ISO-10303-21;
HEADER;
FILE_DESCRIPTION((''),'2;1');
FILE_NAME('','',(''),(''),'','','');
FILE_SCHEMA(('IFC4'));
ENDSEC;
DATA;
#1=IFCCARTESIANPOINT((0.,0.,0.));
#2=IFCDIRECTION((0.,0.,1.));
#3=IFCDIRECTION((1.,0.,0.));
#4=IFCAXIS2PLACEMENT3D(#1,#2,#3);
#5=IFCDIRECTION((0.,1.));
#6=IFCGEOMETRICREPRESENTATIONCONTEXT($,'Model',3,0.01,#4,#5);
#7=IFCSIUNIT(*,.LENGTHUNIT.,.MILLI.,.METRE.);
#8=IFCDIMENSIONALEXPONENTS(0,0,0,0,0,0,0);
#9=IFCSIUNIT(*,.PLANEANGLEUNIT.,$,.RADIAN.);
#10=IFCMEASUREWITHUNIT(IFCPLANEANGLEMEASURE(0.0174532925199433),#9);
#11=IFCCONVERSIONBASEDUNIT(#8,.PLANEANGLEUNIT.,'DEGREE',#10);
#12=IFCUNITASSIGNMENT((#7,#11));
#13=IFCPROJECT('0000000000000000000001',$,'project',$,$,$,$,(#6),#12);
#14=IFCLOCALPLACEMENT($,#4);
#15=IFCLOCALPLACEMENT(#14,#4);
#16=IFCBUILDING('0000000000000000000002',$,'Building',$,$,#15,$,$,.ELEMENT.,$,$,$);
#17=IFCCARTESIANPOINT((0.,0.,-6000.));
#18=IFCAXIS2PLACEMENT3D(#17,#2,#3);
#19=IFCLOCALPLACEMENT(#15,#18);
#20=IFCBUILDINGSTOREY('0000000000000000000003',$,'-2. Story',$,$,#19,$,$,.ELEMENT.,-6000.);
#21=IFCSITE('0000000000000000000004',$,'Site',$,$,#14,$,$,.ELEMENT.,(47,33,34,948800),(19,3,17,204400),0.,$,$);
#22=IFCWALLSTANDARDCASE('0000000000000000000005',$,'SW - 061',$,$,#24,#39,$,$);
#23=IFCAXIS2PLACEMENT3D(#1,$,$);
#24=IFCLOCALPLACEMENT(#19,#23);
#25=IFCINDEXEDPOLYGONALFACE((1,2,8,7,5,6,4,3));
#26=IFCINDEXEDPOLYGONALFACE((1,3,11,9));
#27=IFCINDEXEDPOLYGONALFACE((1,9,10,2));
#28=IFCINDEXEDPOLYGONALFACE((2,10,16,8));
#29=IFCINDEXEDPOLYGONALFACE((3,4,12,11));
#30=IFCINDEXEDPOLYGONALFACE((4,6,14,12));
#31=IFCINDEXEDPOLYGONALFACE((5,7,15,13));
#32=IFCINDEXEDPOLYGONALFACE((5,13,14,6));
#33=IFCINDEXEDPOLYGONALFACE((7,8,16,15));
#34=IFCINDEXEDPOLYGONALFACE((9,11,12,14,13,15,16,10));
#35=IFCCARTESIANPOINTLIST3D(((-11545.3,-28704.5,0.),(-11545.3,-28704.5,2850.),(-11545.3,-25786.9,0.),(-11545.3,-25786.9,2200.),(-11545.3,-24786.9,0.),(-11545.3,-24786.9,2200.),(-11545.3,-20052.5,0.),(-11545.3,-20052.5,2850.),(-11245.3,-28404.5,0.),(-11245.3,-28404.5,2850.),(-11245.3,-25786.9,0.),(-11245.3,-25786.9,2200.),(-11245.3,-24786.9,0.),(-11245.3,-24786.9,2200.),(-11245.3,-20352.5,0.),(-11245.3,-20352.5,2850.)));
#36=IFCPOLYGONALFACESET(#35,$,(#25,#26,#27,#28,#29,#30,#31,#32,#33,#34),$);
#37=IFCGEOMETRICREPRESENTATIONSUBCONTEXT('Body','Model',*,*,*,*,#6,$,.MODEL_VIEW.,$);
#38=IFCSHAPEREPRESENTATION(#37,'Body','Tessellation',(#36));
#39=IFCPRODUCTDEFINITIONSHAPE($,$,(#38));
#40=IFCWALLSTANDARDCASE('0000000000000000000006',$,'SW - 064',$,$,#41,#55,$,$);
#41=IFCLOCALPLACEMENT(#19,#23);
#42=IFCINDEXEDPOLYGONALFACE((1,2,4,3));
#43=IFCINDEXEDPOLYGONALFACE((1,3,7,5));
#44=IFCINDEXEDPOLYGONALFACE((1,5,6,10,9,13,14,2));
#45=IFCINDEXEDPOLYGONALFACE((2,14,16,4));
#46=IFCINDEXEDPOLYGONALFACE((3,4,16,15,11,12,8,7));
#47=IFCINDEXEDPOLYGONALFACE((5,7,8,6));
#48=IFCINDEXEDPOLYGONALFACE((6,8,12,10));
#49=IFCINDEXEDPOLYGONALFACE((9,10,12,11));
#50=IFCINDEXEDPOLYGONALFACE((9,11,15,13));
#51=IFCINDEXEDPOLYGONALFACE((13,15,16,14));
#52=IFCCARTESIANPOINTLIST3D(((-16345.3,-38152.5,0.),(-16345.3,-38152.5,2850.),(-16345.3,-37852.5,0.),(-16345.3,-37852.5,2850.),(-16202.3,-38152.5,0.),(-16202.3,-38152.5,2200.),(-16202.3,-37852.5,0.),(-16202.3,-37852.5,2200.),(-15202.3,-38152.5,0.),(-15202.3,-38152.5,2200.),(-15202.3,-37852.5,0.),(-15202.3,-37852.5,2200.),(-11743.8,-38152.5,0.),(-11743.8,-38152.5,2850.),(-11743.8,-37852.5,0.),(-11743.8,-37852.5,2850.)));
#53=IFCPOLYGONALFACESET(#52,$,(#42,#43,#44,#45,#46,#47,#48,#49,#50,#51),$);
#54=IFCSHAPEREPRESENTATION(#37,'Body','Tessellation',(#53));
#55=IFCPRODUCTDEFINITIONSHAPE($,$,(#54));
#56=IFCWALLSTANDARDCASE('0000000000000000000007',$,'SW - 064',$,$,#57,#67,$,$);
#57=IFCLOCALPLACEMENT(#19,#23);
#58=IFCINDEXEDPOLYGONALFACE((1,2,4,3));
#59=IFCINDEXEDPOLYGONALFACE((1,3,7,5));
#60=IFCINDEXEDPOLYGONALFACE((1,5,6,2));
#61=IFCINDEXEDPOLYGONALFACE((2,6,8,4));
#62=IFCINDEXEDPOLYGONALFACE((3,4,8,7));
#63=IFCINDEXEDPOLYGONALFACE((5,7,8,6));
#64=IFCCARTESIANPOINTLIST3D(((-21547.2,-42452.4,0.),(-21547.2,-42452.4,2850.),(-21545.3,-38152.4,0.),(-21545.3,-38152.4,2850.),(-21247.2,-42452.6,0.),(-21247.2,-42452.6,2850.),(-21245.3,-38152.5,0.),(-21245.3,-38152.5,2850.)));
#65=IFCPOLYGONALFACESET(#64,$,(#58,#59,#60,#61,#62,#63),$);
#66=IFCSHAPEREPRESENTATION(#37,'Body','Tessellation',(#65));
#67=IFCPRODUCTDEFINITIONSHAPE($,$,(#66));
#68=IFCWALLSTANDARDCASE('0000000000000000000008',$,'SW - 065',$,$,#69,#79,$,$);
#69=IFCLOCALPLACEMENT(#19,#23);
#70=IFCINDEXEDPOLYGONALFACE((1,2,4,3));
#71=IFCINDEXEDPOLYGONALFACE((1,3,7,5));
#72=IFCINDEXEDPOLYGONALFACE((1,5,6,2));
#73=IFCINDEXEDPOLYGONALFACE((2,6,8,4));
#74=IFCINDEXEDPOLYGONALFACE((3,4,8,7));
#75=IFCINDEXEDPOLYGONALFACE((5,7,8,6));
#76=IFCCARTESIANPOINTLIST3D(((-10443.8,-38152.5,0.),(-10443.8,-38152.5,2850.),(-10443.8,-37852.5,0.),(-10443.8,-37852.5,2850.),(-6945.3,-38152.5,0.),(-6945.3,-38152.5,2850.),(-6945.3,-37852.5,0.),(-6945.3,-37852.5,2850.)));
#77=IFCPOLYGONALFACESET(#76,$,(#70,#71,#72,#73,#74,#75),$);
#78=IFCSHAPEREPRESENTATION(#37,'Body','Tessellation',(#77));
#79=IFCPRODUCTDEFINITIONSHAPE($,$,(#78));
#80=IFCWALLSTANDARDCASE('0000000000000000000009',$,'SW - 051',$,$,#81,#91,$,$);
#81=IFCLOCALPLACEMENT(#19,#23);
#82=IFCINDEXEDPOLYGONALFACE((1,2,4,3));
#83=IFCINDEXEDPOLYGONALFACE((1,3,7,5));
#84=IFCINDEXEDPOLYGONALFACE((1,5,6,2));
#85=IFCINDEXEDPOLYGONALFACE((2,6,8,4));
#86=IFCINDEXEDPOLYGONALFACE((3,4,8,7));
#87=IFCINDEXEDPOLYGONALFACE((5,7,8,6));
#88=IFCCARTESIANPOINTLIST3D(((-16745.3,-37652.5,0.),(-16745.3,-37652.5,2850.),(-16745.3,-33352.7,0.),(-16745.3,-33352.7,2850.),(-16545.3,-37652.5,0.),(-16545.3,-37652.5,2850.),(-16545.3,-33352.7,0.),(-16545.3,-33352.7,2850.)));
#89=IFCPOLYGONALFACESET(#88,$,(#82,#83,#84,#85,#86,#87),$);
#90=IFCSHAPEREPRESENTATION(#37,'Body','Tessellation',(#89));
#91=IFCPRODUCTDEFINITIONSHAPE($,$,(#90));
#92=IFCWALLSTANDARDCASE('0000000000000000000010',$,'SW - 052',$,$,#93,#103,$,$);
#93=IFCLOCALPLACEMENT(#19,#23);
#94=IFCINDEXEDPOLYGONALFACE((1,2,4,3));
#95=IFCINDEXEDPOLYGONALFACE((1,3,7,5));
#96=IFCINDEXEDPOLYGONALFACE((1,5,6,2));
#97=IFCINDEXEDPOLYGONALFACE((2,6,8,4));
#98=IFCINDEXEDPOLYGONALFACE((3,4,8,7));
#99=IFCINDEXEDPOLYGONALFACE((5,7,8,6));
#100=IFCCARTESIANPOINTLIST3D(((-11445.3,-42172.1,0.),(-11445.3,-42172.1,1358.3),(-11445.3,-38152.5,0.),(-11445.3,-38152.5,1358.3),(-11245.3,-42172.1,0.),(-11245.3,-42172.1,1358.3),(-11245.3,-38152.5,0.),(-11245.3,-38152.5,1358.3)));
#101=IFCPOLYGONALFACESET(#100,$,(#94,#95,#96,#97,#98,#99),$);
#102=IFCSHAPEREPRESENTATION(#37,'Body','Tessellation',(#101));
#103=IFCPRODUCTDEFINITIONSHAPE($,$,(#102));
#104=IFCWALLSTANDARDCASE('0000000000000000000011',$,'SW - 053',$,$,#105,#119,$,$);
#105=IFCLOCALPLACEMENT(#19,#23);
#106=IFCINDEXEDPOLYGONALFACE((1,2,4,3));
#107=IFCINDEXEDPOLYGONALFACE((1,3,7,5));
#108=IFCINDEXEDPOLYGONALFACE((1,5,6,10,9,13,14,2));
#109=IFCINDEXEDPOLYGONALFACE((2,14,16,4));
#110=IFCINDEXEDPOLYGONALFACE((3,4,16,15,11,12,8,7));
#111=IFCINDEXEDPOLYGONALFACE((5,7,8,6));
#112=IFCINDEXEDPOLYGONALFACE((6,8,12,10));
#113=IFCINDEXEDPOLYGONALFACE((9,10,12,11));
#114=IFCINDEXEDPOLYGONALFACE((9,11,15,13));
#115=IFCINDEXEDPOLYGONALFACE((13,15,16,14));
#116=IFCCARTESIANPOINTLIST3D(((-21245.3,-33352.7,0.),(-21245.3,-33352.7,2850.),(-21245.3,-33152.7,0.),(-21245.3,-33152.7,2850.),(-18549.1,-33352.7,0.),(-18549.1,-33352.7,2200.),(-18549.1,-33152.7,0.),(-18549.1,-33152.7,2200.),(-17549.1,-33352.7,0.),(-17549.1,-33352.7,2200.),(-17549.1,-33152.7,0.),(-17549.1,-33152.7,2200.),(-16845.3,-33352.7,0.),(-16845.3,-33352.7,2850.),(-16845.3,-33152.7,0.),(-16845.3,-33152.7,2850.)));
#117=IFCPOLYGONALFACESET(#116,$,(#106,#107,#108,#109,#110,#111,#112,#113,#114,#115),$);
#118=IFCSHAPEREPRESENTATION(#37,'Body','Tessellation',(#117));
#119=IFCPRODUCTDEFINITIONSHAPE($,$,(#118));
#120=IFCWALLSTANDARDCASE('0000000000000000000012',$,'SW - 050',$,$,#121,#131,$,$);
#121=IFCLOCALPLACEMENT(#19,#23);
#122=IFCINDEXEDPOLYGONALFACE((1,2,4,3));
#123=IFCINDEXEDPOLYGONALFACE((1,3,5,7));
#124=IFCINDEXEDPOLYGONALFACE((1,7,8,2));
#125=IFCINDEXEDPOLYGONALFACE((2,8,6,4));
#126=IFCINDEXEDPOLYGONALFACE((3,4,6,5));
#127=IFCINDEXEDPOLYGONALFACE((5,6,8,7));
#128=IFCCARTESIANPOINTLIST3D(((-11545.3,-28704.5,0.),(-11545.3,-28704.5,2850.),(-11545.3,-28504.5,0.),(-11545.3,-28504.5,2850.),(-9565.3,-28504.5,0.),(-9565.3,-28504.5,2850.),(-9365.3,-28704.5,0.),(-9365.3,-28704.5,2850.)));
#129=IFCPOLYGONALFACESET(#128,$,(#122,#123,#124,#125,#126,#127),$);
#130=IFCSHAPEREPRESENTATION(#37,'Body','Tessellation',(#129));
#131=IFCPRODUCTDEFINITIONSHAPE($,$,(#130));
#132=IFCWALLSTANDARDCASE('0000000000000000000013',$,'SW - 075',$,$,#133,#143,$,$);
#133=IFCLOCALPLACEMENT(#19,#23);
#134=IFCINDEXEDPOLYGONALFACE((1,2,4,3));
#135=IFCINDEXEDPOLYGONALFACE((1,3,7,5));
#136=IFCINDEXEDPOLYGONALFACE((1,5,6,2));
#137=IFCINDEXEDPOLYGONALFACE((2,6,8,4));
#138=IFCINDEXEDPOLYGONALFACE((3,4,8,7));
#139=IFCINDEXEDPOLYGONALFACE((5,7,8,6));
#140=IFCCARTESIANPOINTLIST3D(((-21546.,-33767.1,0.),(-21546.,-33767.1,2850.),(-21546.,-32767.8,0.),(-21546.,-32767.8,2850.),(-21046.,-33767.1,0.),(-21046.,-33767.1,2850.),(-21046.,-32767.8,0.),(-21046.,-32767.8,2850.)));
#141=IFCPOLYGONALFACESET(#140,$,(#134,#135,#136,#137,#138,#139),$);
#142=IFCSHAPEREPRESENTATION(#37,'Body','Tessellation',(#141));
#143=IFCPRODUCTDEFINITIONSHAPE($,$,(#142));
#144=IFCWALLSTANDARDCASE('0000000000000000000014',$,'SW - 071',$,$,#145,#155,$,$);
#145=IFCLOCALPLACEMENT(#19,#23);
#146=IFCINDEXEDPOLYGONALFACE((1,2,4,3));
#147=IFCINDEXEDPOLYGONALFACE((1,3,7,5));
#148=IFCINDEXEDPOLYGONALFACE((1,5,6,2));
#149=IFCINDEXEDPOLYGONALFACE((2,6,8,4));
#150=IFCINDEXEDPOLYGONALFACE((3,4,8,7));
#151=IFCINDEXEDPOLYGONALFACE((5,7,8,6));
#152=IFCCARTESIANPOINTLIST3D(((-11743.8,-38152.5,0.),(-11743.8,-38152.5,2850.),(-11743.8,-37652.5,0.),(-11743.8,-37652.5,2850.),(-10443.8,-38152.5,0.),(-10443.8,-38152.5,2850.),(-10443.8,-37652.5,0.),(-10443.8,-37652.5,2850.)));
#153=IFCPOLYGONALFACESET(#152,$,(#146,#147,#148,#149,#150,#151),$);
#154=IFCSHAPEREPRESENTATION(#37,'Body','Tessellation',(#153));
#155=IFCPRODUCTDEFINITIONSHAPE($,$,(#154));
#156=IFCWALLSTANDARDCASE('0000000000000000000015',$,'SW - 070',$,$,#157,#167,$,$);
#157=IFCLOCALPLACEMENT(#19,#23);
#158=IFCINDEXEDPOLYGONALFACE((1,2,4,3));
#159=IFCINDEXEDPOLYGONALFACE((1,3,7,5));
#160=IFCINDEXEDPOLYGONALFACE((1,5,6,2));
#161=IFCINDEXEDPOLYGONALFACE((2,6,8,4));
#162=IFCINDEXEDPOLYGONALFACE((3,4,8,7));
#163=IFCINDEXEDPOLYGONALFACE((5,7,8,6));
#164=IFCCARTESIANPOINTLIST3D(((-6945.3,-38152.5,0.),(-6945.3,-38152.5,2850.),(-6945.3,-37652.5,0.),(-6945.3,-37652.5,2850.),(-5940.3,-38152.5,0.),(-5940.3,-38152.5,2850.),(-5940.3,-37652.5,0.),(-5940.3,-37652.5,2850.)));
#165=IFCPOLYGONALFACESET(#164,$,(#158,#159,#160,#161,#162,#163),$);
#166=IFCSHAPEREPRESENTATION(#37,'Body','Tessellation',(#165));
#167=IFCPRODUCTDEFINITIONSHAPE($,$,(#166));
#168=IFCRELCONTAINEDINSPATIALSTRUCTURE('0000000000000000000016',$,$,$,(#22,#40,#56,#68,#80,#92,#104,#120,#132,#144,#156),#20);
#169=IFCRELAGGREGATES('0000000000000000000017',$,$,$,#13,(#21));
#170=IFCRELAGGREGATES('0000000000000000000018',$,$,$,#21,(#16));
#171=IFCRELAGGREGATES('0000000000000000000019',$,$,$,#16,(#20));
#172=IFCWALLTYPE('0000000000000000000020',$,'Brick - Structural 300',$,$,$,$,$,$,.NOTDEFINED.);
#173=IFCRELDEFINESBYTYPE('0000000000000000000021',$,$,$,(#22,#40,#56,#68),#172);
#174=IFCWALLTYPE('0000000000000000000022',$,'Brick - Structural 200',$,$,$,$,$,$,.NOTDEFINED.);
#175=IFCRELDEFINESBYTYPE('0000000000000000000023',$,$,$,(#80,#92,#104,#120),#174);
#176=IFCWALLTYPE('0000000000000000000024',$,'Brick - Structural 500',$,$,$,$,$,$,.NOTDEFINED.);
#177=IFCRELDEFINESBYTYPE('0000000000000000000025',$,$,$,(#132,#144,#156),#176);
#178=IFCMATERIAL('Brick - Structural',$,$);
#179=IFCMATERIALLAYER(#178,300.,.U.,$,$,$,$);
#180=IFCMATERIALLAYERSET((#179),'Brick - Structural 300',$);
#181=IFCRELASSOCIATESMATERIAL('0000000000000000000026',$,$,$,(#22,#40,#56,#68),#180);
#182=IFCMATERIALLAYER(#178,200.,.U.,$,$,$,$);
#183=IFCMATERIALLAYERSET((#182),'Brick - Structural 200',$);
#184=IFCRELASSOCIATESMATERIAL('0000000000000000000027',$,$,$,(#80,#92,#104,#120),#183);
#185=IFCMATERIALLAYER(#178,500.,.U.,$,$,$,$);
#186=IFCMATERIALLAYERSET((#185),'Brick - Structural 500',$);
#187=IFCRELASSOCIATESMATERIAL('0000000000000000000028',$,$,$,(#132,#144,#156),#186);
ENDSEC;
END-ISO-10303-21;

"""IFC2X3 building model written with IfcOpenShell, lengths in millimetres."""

from ifc_helpers import new_model, entity, si_unit, converted_unit, direction, frame, origin_with_axes, origin_2d_with_axis, place, context, subcontext, project, spatial, polyline, rectangle, outline, extrude, material, layer, layer_set, layer_usage, type_object, element, save


model = new_model("IFC2X3")

# Units and contexts
model_context = context("Model", 3, precision=0.01, world=origin_with_axes(), true_north=direction((0.0, 1.0)))
body_context = subcontext(model_context, "Body", "Model", "MODEL_VIEW")
ifc_project = project(units=[si_unit("LENGTHUNIT", "METRE", prefix="MILLI"), converted_unit("PLANEANGLEUNIT", "DEGREE", entity("IfcPlaneAngleMeasure", 0.0174532925199433), si_unit("PLANEANGLEUNIT", "RADIAN"), dimensions=[0, 0, 0, 0, 0, 0, 0])], contexts=[model_context])

# Site, building, storey
site_placement = place(None, origin_with_axes())
site = spatial("IfcSite", under=ifc_project, at=site_placement, Name="Site", CompositionType="ELEMENT", RefLatitude=(47, 33, 34, 948800), RefLongitude=(19, 3, 17, 204400), RefElevation=0.0)
building_placement = place(site_placement, origin_with_axes())
building = spatial("IfcBuilding", under=site, at=building_placement, Name="Building", CompositionType="ELEMENT")
storey_placement = place(building_placement, frame((0.0, 0.0, -6000.0), z_axis=(0.0, 0.0, 1.0), x_axis=(1.0, 0.0, 0.0)))
storey = spatial("IfcBuildingStorey", under=building, at=storey_placement, Name="-2. Story", CompositionType="ELEMENT", Elevation=-6000.0)

# Shared definitions
ifc_material_1 = material(Name="Brick - Structural")
ifc_layer_1 = layer(ifc_material_1, 300.0, ventilated="UNKNOWN")
ifc_layer_set_1 = layer_set([ifc_layer_1], Name="Brick - Structural 300")
wall_type_1 = type_object("IfcWallType", Name="Brick - Structural 300", PredefinedType="NOTDEFINED")

# Walls, openings
ifc_layer_usage_1 = layer_usage(ifc_layer_set_1, "AXIS2", "NEGATIVE", 0.0)
wall_1_placement = place(storey_placement, frame((-11545.3, -28704.5, 0.0), z_axis=(0.0, 0.0, 1.0), x_axis=(0.0, 1.0, 0.0)))
wall_1 = element("IfcWallStandardCase", 1, at=wall_1_placement, inside=storey, type_object=wall_type_1, material=ifc_layer_usage_1, Name="SW - 061", context=body_context, shape_type="SweptSolid", body=[
    extrude(outline(polyline([(300.0, -300.0), (8351.9, -300.0), (8651.9, 0.0), (0.0, 0.0), (300.0, -300.0)])), origin_with_axes(), (0.0, 0.0, 1.0), 2850.0),
])
opening_1_placement = place(wall_1_placement, frame((3417.6, 0.0, 0.0), z_axis=(0.0, 0.0, 1.0), x_axis=(1.0, 0.0, 0.0)))
element("IfcOpeningElement", 2, at=opening_1_placement, cuts=wall_1, context=body_context, shape_type="SweptSolid", body=[
    extrude(rectangle(XDim=1000.0, YDim=2200.0, at=origin_2d_with_axis()), frame((0.0, -300.0, 1100.0), z_axis=(0.0, 1.0, 0.0), x_axis=(1.0, 0.0, 0.0)), (0.0, 0.0, -1.0), 300.0),
    extrude(rectangle(XDim=1000.0, YDim=2200.0, at=origin_2d_with_axis()), frame((0.0, -300.0, 1100.0), z_axis=(0.0, -1.0, 0.0), x_axis=(1.0, 0.0, 0.0)), (0.0, 0.0, -1.0), 300.0),
])
ifc_layer_usage_2 = layer_usage(ifc_layer_set_1, "AXIS2", "POSITIVE", 0.0)
wall_2_placement = place(storey_placement, frame((-16345.3, -38152.5, 0.0), z_axis=(0.0, 0.0, 1.0), x_axis=(1.0, 0.0, 0.0)))
wall_2 = element("IfcWallStandardCase", 3, at=wall_2_placement, inside=storey, type_object=wall_type_1, material=ifc_layer_usage_2, Name="SW - 064", context=body_context, shape_type="SweptSolid", body=[
    extrude(outline(polyline([(0.0, 0.0), (4601.5, 0.0), (4601.5, 300.0), (0.0, 300.0), (0.0, 0.0)])), origin_with_axes(), (0.0, 0.0, 1.0), 2850.0),
])
opening_2_placement = place(wall_2_placement, frame((643.0, 0.0, 0.0), z_axis=(0.0, 0.0, 1.0), x_axis=(1.0, 0.0, 0.0)))
element("IfcOpeningElement", 4, at=opening_2_placement, cuts=wall_2, context=body_context, shape_type="SweptSolid", body=[
    extrude(rectangle(XDim=1000.0, YDim=2200.0, at=origin_2d_with_axis()), frame((0.0, 300.0, 1100.0), z_axis=(0.0, -1.0, 0.0), x_axis=(1.0, 0.0, 0.0)), (0.0, 0.0, -1.0), 300.0),
    extrude(rectangle(XDim=1000.0, YDim=2200.0, at=origin_2d_with_axis()), frame((0.0, 300.0, 1100.0), z_axis=(0.0, 1.0, 0.0), x_axis=(1.0, 0.0, 0.0)), (0.0, 0.0, -1.0), 300.0),
])

# Walls
ifc_layer_usage_3 = layer_usage(ifc_layer_set_1, "AXIS2", "POSITIVE", 0.0)
wall_3_placement = place(storey_placement, frame((-21247.2, -42452.6, 0.0), z_axis=(0.0, 0.0, 1.0), x_axis=(0.00044, 1.0, 0.0)))
element("IfcWallStandardCase", 5, at=wall_3_placement, inside=storey, type_object=wall_type_1, material=ifc_layer_usage_3, Name="SW - 064", context=body_context, shape_type="SweptSolid", body=[
    extrude(outline(polyline([(0.0, 0.0), (4300.1, 0.0), (4300.1, 300.0), (0.0, 300.0), (0.0, 0.0)])), origin_with_axes(), (0.0, 0.0, 1.0), 2850.0),
])
ifc_layer_usage_4 = layer_usage(ifc_layer_set_1, "AXIS2", "POSITIVE", 0.0)
wall_4_placement = place(storey_placement, frame((-10443.8, -38152.5, 0.0), z_axis=(0.0, 0.0, 1.0), x_axis=(1.0, 0.0, 0.0)))
element("IfcWallStandardCase", 6, at=wall_4_placement, inside=storey, type_object=wall_type_1, material=ifc_layer_usage_4, Name="SW - 065", context=body_context, shape_type="SweptSolid", body=[
    extrude(outline(polyline([(0.0, 0.0), (3498.5, 0.0), (3498.5, 300.0), (0.0, 300.0), (0.0, 0.0)])), origin_with_axes(), (0.0, 0.0, 1.0), 2850.0),
])
ifc_layer_2 = layer(ifc_material_1, 200.0, ventilated="UNKNOWN")
ifc_layer_set_2 = layer_set([ifc_layer_2], Name="Brick - Structural 200")
ifc_layer_usage_5 = layer_usage(ifc_layer_set_2, "AXIS2", "NEGATIVE", 0.0)
wall_type_2 = type_object("IfcWallType", Name="Brick - Structural 200", PredefinedType="NOTDEFINED")
wall_5_placement = place(storey_placement, frame((-16545.3, -33352.7, 0.0), z_axis=(0.0, 0.0, 1.0), x_axis=(0.0, -1.0, 0.0)))
element("IfcWallStandardCase", 7, at=wall_5_placement, inside=storey, type_object=wall_type_2, material=ifc_layer_usage_5, Name="SW - 051", context=body_context, shape_type="SweptSolid", body=[
    extrude(outline(polyline([(0.0, -200.0), (4299.9, -200.0), (4299.9, 0.0), (0.0, 0.0), (0.0, -200.0)])), origin_with_axes(), (0.0, 0.0, 1.0), 2850.0),
])
ifc_layer_usage_6 = layer_usage(ifc_layer_set_2, "AXIS2", "POSITIVE", 0.0)
wall_6_placement = place(storey_placement, frame((-11445.3, -38152.5, 0.0), z_axis=(0.0, 0.0, 1.0), x_axis=(0.0, -1.0, 0.0)))
element("IfcWallStandardCase", 8, at=wall_6_placement, inside=storey, type_object=wall_type_2, material=ifc_layer_usage_6, Name="SW - 052", context=body_context, shape_type="SweptSolid", body=[
    extrude(outline(polyline([(0.0, 0.0), (4019.6, 0.0), (4019.6, 200.0), (0.0, 200.0), (0.0, 0.0)])), origin_with_axes(), (0.0, 0.0, 1.0), 1358.3),
])

# Wall, opening
ifc_layer_usage_7 = layer_usage(ifc_layer_set_2, "AXIS2", "POSITIVE", 0.0)
wall_7_placement = place(storey_placement, frame((-16845.3, -33152.7, 0.0), z_axis=(0.0, 0.0, 1.0), x_axis=(-1.0, 0.0, 0.0)))
wall_7 = element("IfcWallStandardCase", 9, at=wall_7_placement, inside=storey, type_object=wall_type_2, material=ifc_layer_usage_7, Name="SW - 053", context=body_context, shape_type="SweptSolid", body=[
    extrude(outline(polyline([(0.0, 0.0), (4400.0, 0.0), (4400.0, 200.0), (0.0, 200.0), (0.0, 0.0)])), origin_with_axes(), (0.0, 0.0, 1.0), 2850.0),
])
opening_3_placement = place(wall_7_placement, frame((1203.8, 0.0, 0.0), z_axis=(0.0, 0.0, 1.0), x_axis=(1.0, 0.0, 0.0)))
element("IfcOpeningElement", 10, at=opening_3_placement, cuts=wall_7, context=body_context, shape_type="SweptSolid", body=[
    extrude(rectangle(XDim=1000.0, YDim=2200.0, at=origin_2d_with_axis()), frame((0.0, 200.0, 1100.0), z_axis=(0.0, -1.0, 0.0), x_axis=(1.0, 0.0, 0.0)), (0.0, 0.0, -1.0), 200.0),
    extrude(rectangle(XDim=1000.0, YDim=2200.0, at=origin_2d_with_axis()), frame((0.0, 200.0, 1100.0), z_axis=(0.0, 1.0, 0.0), x_axis=(1.0, 0.0, 0.0)), (0.0, 0.0, -1.0), 200.0),
])

# Walls
ifc_layer_usage_8 = layer_usage(ifc_layer_set_2, "AXIS2", "POSITIVE", 0.0)
wall_8_placement = place(storey_placement, frame((-11545.3, -28704.5, 0.0), z_axis=(0.0, 0.0, 1.0), x_axis=(1.0, 0.0, 0.0)))
element("IfcWallStandardCase", 11, at=wall_8_placement, inside=storey, type_object=wall_type_2, material=ifc_layer_usage_8, Name="SW - 050", context=body_context, shape_type="SweptSolid", body=[
    extrude(outline(polyline([(0.0, 0.0), (2180.0, 0.0), (1980.0, 200.0), (0.0, 200.0), (0.0, 0.0)])), origin_with_axes(), (0.0, 0.0, 1.0), 2850.0),
])
ifc_layer_3 = layer(ifc_material_1, 500.0, ventilated="UNKNOWN")
ifc_layer_set_3 = layer_set([ifc_layer_3], Name="Brick - Structural 500")
ifc_layer_usage_9 = layer_usage(ifc_layer_set_3, "AXIS2", "NEGATIVE", 0.0)
wall_type_3 = type_object("IfcWallType", Name="Brick - Structural 500", PredefinedType="NOTDEFINED")
wall_9_placement = place(storey_placement, frame((-21546.0, -33767.1, 0.0), z_axis=(0.0, 0.0, 1.0), x_axis=(0.0, 1.0, 0.0)))
element("IfcWallStandardCase", 12, at=wall_9_placement, inside=storey, type_object=wall_type_3, material=ifc_layer_usage_9, Name="SW - 075", context=body_context, shape_type="SweptSolid", body=[
    extrude(outline(polyline([(0.0, -500.0), (999.3, -500.0), (999.3, 0.0), (0.0, 0.0), (0.0, -500.0)])), origin_with_axes(), (0.0, 0.0, 1.0), 2850.0),
])
ifc_layer_usage_10 = layer_usage(ifc_layer_set_3, "AXIS2", "NEGATIVE", 0.0)
wall_10_placement = place(storey_placement, frame((-10443.8, -38152.5, 0.0), z_axis=(0.0, 0.0, 1.0), x_axis=(-1.0, 0.0, 0.0)))
element("IfcWallStandardCase", 13, at=wall_10_placement, inside=storey, type_object=wall_type_3, material=ifc_layer_usage_10, Name="SW - 071", context=body_context, shape_type="SweptSolid", body=[
    extrude(outline(polyline([(0.0, -500.0), (1300.0, -500.0), (1300.0, 0.0), (0.0, 0.0), (0.0, -500.0)])), origin_with_axes(), (0.0, 0.0, 1.0), 2850.0),
])
ifc_layer_usage_11 = layer_usage(ifc_layer_set_3, "AXIS2", "NEGATIVE", 0.0)
wall_11_placement = place(storey_placement, frame((-5940.3, -38152.5, 0.0), z_axis=(0.0, 0.0, 1.0), x_axis=(-1.0, 0.0, 0.0)))
element("IfcWallStandardCase", 14, at=wall_11_placement, inside=storey, type_object=wall_type_3, material=ifc_layer_usage_11, Name="SW - 070", context=body_context, shape_type="SweptSolid", body=[
    extrude(outline(polyline([(0.0, -500.0), (1005.1, -500.0), (1005.1, 0.0), (0.0, 0.0), (0.0, -500.0)])), origin_with_axes(), (0.0, 0.0, 1.0), 2850.0),
])

save(model, "model.ifc")
